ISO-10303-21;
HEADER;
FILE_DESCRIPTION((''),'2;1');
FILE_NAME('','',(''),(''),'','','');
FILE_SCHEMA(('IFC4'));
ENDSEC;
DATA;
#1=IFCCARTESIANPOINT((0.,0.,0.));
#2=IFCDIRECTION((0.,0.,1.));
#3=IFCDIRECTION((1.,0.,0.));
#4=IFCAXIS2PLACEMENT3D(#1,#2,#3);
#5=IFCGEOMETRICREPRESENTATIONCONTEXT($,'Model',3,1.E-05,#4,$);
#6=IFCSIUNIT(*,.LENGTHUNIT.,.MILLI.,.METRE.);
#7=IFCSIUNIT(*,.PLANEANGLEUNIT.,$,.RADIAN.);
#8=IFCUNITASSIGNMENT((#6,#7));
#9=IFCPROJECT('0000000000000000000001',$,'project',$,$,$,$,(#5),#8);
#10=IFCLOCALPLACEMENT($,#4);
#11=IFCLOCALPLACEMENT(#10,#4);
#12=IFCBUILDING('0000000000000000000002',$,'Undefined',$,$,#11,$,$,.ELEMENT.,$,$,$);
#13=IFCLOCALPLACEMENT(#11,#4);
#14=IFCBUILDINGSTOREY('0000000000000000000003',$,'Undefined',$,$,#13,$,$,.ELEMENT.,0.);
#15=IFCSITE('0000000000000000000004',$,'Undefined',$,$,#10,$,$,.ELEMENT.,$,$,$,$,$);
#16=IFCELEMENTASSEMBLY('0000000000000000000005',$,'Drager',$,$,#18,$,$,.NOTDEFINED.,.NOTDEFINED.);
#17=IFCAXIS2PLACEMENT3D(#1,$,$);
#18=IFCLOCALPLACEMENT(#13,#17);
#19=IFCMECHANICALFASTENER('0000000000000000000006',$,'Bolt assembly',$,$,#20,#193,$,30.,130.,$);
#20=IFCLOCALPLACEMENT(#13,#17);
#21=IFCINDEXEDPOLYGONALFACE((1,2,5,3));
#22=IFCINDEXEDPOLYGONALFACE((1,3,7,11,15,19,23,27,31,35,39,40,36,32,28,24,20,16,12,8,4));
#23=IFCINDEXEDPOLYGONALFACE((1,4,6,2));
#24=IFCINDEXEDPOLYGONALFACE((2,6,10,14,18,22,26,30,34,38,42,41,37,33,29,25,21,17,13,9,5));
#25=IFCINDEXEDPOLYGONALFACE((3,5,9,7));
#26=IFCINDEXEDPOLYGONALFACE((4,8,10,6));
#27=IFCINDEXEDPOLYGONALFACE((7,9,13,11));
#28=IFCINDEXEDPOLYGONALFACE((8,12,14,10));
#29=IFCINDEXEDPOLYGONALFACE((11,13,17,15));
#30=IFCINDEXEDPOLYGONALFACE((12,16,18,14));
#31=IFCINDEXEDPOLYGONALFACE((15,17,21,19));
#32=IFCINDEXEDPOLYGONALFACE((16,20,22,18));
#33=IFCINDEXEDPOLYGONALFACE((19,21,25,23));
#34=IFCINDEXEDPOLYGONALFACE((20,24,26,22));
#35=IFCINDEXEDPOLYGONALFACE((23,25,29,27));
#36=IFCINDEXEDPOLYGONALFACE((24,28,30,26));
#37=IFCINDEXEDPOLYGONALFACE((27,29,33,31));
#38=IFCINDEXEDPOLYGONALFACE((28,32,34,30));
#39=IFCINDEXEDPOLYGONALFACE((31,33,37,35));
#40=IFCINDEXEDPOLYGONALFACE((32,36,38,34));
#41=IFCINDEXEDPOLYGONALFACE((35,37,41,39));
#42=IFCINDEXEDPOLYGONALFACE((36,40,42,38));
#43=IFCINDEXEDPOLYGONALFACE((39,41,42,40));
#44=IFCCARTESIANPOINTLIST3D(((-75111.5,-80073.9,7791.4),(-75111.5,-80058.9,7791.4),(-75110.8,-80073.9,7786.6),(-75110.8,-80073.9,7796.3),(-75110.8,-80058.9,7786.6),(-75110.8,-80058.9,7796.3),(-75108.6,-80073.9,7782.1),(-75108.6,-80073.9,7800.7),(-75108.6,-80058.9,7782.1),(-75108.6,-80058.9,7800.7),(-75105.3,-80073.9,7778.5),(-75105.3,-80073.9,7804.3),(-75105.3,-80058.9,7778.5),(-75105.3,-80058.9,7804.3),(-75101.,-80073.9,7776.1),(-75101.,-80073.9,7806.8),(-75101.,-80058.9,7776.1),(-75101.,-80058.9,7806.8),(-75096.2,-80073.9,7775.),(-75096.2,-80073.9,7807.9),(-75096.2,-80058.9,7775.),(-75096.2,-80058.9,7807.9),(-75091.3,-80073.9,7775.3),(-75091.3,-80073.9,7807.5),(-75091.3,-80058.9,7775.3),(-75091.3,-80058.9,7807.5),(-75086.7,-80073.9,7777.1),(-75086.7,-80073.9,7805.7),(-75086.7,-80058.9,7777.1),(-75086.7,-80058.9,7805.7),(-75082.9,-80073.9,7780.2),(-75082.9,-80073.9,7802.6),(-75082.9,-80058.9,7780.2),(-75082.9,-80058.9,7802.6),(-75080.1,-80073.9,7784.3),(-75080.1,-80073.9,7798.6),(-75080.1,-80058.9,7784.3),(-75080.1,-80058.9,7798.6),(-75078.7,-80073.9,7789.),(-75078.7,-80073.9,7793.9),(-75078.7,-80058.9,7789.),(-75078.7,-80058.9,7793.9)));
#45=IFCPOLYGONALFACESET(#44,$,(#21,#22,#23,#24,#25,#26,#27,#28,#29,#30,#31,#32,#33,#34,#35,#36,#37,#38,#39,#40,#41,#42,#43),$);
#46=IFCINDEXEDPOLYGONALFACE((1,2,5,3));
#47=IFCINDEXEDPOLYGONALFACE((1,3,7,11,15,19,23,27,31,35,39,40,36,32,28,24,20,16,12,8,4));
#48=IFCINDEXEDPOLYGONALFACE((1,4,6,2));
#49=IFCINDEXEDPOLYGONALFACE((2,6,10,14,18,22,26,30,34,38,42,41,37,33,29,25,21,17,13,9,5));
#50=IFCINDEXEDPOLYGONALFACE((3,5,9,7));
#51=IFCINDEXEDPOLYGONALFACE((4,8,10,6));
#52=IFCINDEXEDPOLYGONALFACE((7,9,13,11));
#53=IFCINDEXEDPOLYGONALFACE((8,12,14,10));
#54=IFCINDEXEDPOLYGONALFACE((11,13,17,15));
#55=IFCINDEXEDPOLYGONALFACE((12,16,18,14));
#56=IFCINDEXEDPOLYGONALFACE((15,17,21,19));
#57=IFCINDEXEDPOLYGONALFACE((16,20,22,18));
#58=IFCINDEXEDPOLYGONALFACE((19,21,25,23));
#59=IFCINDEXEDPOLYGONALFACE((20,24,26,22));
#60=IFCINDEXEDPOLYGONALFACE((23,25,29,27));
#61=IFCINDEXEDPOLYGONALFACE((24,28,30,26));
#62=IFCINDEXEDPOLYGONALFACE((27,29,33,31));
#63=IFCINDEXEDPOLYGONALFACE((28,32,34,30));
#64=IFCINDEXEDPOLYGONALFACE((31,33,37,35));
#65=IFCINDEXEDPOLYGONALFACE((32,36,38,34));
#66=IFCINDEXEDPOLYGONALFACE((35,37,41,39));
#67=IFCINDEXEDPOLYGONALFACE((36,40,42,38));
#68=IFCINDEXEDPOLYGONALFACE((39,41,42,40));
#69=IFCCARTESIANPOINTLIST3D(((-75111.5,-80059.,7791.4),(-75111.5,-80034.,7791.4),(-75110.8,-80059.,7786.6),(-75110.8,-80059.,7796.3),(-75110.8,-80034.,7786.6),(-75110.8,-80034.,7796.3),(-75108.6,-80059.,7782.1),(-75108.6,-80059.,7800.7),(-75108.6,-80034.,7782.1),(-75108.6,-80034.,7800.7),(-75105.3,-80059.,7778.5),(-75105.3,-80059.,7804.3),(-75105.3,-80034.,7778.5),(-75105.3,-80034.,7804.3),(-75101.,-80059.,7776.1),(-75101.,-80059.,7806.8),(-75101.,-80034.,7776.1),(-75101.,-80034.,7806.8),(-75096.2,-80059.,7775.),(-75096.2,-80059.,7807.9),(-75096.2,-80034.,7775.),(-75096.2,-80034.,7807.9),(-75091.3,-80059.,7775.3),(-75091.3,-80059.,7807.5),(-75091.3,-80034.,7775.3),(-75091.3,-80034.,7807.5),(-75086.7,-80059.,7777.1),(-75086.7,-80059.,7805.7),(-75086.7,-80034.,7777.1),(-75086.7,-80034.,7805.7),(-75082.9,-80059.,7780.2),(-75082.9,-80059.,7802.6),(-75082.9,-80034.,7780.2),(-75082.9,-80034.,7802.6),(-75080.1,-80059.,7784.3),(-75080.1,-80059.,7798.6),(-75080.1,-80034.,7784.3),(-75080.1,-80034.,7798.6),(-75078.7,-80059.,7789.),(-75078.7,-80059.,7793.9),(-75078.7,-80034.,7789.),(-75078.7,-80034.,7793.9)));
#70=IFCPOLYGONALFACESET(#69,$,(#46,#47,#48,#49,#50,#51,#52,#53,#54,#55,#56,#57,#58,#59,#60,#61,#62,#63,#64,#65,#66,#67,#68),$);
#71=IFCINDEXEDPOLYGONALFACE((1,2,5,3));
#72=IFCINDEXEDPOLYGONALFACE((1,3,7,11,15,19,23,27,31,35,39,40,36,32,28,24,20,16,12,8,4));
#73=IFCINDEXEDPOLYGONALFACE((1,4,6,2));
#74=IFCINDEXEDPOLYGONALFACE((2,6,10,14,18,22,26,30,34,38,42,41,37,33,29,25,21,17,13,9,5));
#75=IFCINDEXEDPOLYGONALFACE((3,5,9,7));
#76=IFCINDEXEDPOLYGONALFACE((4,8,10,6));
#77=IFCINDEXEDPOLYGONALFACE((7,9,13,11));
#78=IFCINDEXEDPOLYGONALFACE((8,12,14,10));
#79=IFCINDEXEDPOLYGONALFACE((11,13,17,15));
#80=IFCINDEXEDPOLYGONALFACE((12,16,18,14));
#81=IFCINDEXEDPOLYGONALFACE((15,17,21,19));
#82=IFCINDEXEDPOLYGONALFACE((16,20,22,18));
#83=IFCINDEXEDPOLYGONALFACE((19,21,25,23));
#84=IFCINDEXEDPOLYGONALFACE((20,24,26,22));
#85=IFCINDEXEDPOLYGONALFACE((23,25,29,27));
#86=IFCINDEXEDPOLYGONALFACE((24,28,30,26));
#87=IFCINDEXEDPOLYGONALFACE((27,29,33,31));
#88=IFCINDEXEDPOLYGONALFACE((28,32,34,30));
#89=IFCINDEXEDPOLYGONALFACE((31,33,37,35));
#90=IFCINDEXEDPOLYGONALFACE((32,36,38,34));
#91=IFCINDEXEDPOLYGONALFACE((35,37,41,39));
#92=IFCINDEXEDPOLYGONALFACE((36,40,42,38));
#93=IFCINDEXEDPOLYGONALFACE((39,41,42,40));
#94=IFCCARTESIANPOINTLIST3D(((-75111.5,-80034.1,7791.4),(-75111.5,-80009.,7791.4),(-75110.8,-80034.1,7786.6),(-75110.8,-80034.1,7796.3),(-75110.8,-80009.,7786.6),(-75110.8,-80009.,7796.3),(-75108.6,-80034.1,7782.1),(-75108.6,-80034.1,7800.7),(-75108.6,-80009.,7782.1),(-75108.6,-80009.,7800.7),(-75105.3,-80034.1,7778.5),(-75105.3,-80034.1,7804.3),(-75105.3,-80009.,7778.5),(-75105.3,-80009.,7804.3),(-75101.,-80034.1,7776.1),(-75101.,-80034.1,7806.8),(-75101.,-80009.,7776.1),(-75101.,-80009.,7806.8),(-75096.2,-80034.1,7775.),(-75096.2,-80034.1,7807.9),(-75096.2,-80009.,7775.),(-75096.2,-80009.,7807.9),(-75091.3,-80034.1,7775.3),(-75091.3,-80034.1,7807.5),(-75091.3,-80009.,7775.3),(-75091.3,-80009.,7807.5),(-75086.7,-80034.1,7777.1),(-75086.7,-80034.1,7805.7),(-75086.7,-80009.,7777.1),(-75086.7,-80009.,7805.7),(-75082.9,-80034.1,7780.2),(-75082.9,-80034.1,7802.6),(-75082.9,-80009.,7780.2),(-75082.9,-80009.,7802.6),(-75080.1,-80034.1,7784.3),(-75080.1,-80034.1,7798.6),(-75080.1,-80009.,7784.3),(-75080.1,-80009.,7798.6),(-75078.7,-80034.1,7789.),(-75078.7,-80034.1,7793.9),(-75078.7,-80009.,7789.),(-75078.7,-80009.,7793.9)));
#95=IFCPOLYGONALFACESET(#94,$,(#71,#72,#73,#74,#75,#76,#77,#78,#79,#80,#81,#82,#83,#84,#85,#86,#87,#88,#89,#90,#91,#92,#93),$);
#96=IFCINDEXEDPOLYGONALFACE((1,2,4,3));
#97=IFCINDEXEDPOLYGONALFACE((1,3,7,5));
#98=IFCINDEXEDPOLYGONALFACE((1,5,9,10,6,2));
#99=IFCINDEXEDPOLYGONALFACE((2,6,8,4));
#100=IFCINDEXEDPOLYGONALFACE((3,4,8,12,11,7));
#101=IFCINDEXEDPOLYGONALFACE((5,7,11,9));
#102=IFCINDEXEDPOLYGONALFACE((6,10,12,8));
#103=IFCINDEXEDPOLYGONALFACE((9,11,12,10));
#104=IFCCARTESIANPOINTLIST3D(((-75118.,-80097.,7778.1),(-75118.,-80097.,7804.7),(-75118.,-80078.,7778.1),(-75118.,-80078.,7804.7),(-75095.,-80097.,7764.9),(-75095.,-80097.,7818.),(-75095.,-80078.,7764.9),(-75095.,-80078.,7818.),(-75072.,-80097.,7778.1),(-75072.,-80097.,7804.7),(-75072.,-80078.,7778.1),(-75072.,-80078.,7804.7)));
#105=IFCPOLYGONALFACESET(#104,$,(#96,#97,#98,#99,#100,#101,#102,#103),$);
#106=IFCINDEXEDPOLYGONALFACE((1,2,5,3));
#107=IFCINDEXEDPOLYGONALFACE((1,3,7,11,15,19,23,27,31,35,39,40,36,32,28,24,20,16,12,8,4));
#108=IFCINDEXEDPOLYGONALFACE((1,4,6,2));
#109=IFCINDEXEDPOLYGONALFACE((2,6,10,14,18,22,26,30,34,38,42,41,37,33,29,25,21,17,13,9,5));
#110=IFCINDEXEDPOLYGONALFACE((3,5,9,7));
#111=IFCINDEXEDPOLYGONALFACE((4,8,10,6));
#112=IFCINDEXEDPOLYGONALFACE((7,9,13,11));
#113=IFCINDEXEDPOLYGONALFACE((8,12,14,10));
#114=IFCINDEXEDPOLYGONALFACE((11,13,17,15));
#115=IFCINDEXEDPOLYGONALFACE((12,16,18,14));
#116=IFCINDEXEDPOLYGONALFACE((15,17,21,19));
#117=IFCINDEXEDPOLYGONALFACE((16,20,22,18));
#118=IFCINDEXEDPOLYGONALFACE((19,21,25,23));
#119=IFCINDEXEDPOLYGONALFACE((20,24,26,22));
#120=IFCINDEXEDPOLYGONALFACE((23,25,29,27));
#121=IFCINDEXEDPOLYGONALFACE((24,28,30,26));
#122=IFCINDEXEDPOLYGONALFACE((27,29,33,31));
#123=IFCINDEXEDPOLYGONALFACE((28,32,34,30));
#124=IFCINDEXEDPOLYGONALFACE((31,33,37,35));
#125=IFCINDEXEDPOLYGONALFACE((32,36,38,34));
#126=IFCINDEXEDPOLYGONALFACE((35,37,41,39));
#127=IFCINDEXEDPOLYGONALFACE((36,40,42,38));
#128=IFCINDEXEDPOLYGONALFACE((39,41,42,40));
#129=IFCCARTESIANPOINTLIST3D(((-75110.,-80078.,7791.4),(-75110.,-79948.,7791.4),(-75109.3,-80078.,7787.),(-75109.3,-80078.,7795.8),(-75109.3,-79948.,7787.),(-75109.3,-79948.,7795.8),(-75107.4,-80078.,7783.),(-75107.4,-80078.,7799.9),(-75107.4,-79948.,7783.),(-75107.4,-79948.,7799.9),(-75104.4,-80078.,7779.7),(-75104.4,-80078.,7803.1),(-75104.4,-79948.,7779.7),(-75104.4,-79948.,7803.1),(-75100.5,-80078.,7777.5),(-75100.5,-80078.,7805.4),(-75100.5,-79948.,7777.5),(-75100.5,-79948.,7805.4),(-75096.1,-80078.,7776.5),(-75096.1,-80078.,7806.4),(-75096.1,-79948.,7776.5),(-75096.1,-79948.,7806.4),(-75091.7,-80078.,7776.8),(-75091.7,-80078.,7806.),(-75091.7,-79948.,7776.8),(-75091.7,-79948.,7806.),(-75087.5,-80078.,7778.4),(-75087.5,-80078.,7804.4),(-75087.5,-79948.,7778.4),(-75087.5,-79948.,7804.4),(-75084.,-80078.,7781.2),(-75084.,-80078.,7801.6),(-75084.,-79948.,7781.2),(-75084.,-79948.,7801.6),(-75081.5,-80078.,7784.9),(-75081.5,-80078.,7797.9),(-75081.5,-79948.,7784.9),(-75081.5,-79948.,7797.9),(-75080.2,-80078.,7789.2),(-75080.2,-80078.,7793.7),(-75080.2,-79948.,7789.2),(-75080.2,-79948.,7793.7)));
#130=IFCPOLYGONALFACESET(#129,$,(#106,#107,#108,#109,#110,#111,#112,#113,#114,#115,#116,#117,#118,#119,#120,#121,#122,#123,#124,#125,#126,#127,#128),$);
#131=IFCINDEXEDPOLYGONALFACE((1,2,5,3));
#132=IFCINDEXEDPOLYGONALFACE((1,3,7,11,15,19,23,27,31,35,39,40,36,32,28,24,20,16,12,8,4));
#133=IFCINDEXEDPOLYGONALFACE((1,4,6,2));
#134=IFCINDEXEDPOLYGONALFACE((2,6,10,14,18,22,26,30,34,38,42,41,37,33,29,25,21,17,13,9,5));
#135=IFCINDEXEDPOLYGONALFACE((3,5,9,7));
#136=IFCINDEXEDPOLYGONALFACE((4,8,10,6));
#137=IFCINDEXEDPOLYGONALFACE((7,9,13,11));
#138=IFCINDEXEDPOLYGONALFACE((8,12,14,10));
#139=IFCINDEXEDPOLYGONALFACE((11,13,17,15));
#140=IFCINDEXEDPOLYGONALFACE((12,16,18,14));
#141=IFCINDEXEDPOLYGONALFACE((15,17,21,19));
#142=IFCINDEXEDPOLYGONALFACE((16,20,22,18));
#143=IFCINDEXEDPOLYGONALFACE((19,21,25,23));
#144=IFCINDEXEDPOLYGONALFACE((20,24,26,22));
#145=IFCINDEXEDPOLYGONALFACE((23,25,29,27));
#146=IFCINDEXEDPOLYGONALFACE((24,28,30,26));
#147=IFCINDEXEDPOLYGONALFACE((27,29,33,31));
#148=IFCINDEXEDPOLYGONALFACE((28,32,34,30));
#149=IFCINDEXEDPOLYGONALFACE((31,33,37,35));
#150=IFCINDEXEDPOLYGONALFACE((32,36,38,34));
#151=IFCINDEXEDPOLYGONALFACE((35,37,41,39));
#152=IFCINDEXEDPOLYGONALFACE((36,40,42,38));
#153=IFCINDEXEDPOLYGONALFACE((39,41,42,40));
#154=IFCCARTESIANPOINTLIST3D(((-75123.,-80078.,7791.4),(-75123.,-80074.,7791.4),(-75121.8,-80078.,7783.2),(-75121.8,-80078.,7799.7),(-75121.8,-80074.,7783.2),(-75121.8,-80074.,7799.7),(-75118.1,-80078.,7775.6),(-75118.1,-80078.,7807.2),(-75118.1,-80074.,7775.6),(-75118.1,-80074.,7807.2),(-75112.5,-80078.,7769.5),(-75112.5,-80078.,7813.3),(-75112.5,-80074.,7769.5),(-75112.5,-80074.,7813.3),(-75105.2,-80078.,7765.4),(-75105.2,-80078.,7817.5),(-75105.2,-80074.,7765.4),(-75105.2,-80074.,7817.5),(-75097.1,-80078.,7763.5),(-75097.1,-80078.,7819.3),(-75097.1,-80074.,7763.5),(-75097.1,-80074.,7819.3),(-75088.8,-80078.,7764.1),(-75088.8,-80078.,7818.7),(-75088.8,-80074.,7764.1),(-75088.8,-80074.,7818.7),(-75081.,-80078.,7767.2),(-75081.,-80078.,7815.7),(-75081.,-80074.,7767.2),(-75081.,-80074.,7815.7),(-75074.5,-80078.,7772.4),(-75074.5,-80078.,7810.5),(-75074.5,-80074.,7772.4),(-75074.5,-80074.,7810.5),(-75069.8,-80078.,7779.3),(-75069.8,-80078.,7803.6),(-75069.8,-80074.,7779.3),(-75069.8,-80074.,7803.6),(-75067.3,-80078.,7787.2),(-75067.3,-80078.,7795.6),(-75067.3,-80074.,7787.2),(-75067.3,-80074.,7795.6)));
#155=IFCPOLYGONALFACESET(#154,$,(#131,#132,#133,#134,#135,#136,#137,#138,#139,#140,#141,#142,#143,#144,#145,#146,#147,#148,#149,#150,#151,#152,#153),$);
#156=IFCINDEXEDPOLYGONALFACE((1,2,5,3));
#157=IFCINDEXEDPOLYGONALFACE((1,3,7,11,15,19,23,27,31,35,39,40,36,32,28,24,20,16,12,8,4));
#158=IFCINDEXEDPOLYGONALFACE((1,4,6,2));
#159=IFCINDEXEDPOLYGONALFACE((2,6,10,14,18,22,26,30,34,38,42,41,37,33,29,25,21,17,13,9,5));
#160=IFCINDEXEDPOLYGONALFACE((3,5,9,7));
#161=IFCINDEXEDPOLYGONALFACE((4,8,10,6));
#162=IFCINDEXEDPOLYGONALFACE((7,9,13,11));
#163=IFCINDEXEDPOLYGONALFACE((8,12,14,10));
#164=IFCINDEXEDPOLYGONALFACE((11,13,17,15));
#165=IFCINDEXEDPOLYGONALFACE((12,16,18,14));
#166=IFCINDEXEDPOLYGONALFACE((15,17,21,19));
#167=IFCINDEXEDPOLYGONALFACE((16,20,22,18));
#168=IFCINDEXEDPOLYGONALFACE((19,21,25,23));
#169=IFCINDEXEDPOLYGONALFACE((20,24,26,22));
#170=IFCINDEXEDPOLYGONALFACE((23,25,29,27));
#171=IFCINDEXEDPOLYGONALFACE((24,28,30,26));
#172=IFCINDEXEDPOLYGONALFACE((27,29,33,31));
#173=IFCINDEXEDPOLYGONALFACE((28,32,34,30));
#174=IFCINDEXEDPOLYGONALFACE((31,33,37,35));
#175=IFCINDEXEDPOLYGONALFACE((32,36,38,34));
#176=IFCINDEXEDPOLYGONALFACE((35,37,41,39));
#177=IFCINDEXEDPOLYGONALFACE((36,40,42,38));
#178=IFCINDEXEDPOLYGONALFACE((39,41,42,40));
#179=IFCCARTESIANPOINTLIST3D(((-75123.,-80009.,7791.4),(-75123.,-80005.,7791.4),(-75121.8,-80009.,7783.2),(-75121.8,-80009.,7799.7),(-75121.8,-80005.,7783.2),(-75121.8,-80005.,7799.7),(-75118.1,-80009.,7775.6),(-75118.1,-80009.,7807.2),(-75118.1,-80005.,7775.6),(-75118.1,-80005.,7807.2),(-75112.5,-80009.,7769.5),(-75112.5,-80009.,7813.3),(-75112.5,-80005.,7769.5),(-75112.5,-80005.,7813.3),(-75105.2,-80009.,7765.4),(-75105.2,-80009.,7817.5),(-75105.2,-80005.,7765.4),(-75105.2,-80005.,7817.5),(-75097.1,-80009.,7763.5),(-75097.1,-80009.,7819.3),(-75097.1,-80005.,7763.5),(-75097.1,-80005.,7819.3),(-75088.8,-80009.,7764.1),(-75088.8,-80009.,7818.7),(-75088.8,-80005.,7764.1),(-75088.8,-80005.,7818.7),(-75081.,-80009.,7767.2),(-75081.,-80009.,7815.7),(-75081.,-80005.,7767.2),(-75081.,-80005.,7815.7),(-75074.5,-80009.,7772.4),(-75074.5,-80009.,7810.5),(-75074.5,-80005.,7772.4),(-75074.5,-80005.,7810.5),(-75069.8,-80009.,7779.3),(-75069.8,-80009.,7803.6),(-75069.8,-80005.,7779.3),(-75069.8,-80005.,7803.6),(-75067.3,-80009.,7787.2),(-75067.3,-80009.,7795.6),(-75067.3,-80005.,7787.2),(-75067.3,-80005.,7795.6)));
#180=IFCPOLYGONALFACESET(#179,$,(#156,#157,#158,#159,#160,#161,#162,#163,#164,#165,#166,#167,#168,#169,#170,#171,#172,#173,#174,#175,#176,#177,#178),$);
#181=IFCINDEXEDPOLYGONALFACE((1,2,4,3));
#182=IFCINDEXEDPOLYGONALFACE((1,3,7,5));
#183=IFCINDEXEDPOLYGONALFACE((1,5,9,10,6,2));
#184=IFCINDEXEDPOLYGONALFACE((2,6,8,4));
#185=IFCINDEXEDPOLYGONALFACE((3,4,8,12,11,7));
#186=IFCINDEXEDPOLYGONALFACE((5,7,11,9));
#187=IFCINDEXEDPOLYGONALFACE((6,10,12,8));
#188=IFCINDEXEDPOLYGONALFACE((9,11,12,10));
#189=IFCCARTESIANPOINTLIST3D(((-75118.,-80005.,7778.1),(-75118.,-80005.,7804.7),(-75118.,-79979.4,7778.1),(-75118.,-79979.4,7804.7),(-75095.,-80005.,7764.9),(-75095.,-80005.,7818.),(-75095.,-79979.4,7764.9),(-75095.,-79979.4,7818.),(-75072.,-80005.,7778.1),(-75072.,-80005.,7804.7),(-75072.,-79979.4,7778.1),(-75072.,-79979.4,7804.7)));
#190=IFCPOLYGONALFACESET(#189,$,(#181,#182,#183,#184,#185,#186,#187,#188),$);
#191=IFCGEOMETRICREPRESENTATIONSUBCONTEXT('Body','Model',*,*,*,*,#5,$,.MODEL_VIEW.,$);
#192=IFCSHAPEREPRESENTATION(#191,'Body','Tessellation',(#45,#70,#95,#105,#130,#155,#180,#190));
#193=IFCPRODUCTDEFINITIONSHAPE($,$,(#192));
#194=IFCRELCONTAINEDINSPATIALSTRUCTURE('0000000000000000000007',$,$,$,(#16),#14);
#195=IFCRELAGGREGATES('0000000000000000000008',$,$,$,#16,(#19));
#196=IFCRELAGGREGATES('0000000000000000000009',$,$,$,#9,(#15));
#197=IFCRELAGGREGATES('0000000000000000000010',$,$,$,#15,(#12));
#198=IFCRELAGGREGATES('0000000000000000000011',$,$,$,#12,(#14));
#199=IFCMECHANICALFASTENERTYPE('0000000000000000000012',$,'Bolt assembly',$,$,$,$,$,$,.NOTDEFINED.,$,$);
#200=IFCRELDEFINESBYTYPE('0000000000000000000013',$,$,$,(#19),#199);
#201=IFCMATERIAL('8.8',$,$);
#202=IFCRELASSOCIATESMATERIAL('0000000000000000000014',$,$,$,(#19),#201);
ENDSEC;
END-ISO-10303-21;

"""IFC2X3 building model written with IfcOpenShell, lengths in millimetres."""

from ifc_helpers import new_model, si_unit, frame, origin_with_axes, origin_2d_with_axis, place, context, subcontext, project, spatial, polyline, circle, outline, extrude, source, transform, mapped, material, type_object, element, aggregate, save


model = new_model("IFC2X3")

# Units and contexts
model_context = context("Model", 3, precision=1e-05, world=origin_with_axes())
body_context = subcontext(model_context, "Body", "Model", "MODEL_VIEW")
ifc_project = project(units=[si_unit("LENGTHUNIT", "METRE", prefix="MILLI"), si_unit("PLANEANGLEUNIT", "RADIAN")], contexts=[model_context])

# Site, building, storey
site_placement = place(None, origin_with_axes())
site = spatial("IfcSite", under=ifc_project, at=site_placement, Name="Undefined", CompositionType="ELEMENT")
building_placement = place(site_placement, origin_with_axes())
building = spatial("IfcBuilding", under=site, at=building_placement, Name="Undefined", CompositionType="ELEMENT")
storey_placement = place(building_placement, origin_with_axes())
storey = spatial("IfcBuildingStorey", under=building, at=storey_placement, Name="Undefined", CompositionType="ELEMENT", Elevation=0.0)

# Element assembly
assembly_1_placement = place(storey_placement, origin_with_axes())
assembly_1 = element("IfcElementAssembly", 1, at=assembly_1_placement, inside=storey, Name="Drager", AssemblyPlace="NOTDEFINED", PredefinedType="NOTDEFINED")

# Shared definitions
ifc_material_1 = material(Name="8.8")
mechanical_fastener_type = type_object("IfcMechanicalFastenerType", Name="Bolt assembly")

# Mechanical fastener
shared_shape_1 = source(origin_with_axes(), body_context, "Body", "SweptSolid", [
    extrude(circle(Radius=16.5, at=origin_2d_with_axis()), frame((0.0, -7.4, 0.0), z_axis=(0.0, 1.0, 0.0), x_axis=(1.0, 0.0, 0.0)), (0.0, 0.0, 1.0), 15.0),
    extrude(circle(Radius=16.5, at=origin_2d_with_axis()), frame((0.0, 7.5, 0.0), z_axis=(0.0, 1.0, 0.0), x_axis=(1.0, 0.0, 0.0)), (0.0, 0.0, 1.0), 25.0),
    extrude(circle(Radius=16.5, at=origin_2d_with_axis()), frame((0.0, 32.4, 0.0), z_axis=(0.0, 1.0, 0.0), x_axis=(1.0, 0.0, 0.0)), (0.0, 0.0, 1.0), 25.1),
    extrude(outline(polyline([(23.0, -13.3), (23.0, 13.3), (0.0, 26.6), (-23.0, 13.3), (-23.0, -13.3), (0.0, -26.6), (23.0, -13.3)])), frame((0.0, -30.5, 0.0), z_axis=(0.0, 1.0, 0.0), x_axis=(1.0, 0.0, 0.0)), (0.0, 0.0, 1.0), 19.0),
    extrude(circle(Radius=15.0, at=origin_2d_with_axis()), frame((0.0, -11.5, 0.0), z_axis=(0.0, 1.0, 0.0), x_axis=(1.0, 0.0, 0.0)), (0.0, 0.0, 1.0), 130.0),
    extrude(circle(Radius=28.0, at=origin_2d_with_axis()), frame((0.0, -11.5, 0.0), z_axis=(0.0, 1.0, 0.0), x_axis=(1.0, 0.0, 0.0)), (0.0, 0.0, 1.0), 4.0),
    extrude(circle(Radius=28.0, at=origin_2d_with_axis()), frame((0.0, 57.5, 0.0), z_axis=(0.0, 1.0, 0.0), x_axis=(1.0, 0.0, 0.0)), (0.0, 0.0, 1.0), 4.0),
    extrude(outline(polyline([(23.0, -13.3), (23.0, 13.3), (0.0, 26.6), (-23.0, 13.3), (-23.0, -13.3), (0.0, -26.6), (23.0, -13.3)])), frame((0.0, 61.5, 0.0), z_axis=(0.0, 1.0, 0.0), x_axis=(1.0, 0.0, 0.0)), (0.0, 0.0, 1.0), 25.6),
])
mechanical_fastener_1_placement = place(assembly_1_placement, frame((-75095.0, -80066.5, 7791.4), z_axis=(0.0, 0.0, -1.0), x_axis=(-1.0, 0.0, 0.0)))
mechanical_fastener_1 = element("IfcMechanicalFastener", 2, at=mechanical_fastener_1_placement, type_object=mechanical_fastener_type, material=ifc_material_1, Name="Bolt assembly", NominalDiameter=30.0, NominalLength=130.0, context=body_context, shape_type="MappedRepresentation", body=[
    mapped(shared_shape_1, transform((0.0, 0.0, 0.0))),
])
aggregate(assembly_1, [mechanical_fastener_1])

save(model, "model.ifc")
